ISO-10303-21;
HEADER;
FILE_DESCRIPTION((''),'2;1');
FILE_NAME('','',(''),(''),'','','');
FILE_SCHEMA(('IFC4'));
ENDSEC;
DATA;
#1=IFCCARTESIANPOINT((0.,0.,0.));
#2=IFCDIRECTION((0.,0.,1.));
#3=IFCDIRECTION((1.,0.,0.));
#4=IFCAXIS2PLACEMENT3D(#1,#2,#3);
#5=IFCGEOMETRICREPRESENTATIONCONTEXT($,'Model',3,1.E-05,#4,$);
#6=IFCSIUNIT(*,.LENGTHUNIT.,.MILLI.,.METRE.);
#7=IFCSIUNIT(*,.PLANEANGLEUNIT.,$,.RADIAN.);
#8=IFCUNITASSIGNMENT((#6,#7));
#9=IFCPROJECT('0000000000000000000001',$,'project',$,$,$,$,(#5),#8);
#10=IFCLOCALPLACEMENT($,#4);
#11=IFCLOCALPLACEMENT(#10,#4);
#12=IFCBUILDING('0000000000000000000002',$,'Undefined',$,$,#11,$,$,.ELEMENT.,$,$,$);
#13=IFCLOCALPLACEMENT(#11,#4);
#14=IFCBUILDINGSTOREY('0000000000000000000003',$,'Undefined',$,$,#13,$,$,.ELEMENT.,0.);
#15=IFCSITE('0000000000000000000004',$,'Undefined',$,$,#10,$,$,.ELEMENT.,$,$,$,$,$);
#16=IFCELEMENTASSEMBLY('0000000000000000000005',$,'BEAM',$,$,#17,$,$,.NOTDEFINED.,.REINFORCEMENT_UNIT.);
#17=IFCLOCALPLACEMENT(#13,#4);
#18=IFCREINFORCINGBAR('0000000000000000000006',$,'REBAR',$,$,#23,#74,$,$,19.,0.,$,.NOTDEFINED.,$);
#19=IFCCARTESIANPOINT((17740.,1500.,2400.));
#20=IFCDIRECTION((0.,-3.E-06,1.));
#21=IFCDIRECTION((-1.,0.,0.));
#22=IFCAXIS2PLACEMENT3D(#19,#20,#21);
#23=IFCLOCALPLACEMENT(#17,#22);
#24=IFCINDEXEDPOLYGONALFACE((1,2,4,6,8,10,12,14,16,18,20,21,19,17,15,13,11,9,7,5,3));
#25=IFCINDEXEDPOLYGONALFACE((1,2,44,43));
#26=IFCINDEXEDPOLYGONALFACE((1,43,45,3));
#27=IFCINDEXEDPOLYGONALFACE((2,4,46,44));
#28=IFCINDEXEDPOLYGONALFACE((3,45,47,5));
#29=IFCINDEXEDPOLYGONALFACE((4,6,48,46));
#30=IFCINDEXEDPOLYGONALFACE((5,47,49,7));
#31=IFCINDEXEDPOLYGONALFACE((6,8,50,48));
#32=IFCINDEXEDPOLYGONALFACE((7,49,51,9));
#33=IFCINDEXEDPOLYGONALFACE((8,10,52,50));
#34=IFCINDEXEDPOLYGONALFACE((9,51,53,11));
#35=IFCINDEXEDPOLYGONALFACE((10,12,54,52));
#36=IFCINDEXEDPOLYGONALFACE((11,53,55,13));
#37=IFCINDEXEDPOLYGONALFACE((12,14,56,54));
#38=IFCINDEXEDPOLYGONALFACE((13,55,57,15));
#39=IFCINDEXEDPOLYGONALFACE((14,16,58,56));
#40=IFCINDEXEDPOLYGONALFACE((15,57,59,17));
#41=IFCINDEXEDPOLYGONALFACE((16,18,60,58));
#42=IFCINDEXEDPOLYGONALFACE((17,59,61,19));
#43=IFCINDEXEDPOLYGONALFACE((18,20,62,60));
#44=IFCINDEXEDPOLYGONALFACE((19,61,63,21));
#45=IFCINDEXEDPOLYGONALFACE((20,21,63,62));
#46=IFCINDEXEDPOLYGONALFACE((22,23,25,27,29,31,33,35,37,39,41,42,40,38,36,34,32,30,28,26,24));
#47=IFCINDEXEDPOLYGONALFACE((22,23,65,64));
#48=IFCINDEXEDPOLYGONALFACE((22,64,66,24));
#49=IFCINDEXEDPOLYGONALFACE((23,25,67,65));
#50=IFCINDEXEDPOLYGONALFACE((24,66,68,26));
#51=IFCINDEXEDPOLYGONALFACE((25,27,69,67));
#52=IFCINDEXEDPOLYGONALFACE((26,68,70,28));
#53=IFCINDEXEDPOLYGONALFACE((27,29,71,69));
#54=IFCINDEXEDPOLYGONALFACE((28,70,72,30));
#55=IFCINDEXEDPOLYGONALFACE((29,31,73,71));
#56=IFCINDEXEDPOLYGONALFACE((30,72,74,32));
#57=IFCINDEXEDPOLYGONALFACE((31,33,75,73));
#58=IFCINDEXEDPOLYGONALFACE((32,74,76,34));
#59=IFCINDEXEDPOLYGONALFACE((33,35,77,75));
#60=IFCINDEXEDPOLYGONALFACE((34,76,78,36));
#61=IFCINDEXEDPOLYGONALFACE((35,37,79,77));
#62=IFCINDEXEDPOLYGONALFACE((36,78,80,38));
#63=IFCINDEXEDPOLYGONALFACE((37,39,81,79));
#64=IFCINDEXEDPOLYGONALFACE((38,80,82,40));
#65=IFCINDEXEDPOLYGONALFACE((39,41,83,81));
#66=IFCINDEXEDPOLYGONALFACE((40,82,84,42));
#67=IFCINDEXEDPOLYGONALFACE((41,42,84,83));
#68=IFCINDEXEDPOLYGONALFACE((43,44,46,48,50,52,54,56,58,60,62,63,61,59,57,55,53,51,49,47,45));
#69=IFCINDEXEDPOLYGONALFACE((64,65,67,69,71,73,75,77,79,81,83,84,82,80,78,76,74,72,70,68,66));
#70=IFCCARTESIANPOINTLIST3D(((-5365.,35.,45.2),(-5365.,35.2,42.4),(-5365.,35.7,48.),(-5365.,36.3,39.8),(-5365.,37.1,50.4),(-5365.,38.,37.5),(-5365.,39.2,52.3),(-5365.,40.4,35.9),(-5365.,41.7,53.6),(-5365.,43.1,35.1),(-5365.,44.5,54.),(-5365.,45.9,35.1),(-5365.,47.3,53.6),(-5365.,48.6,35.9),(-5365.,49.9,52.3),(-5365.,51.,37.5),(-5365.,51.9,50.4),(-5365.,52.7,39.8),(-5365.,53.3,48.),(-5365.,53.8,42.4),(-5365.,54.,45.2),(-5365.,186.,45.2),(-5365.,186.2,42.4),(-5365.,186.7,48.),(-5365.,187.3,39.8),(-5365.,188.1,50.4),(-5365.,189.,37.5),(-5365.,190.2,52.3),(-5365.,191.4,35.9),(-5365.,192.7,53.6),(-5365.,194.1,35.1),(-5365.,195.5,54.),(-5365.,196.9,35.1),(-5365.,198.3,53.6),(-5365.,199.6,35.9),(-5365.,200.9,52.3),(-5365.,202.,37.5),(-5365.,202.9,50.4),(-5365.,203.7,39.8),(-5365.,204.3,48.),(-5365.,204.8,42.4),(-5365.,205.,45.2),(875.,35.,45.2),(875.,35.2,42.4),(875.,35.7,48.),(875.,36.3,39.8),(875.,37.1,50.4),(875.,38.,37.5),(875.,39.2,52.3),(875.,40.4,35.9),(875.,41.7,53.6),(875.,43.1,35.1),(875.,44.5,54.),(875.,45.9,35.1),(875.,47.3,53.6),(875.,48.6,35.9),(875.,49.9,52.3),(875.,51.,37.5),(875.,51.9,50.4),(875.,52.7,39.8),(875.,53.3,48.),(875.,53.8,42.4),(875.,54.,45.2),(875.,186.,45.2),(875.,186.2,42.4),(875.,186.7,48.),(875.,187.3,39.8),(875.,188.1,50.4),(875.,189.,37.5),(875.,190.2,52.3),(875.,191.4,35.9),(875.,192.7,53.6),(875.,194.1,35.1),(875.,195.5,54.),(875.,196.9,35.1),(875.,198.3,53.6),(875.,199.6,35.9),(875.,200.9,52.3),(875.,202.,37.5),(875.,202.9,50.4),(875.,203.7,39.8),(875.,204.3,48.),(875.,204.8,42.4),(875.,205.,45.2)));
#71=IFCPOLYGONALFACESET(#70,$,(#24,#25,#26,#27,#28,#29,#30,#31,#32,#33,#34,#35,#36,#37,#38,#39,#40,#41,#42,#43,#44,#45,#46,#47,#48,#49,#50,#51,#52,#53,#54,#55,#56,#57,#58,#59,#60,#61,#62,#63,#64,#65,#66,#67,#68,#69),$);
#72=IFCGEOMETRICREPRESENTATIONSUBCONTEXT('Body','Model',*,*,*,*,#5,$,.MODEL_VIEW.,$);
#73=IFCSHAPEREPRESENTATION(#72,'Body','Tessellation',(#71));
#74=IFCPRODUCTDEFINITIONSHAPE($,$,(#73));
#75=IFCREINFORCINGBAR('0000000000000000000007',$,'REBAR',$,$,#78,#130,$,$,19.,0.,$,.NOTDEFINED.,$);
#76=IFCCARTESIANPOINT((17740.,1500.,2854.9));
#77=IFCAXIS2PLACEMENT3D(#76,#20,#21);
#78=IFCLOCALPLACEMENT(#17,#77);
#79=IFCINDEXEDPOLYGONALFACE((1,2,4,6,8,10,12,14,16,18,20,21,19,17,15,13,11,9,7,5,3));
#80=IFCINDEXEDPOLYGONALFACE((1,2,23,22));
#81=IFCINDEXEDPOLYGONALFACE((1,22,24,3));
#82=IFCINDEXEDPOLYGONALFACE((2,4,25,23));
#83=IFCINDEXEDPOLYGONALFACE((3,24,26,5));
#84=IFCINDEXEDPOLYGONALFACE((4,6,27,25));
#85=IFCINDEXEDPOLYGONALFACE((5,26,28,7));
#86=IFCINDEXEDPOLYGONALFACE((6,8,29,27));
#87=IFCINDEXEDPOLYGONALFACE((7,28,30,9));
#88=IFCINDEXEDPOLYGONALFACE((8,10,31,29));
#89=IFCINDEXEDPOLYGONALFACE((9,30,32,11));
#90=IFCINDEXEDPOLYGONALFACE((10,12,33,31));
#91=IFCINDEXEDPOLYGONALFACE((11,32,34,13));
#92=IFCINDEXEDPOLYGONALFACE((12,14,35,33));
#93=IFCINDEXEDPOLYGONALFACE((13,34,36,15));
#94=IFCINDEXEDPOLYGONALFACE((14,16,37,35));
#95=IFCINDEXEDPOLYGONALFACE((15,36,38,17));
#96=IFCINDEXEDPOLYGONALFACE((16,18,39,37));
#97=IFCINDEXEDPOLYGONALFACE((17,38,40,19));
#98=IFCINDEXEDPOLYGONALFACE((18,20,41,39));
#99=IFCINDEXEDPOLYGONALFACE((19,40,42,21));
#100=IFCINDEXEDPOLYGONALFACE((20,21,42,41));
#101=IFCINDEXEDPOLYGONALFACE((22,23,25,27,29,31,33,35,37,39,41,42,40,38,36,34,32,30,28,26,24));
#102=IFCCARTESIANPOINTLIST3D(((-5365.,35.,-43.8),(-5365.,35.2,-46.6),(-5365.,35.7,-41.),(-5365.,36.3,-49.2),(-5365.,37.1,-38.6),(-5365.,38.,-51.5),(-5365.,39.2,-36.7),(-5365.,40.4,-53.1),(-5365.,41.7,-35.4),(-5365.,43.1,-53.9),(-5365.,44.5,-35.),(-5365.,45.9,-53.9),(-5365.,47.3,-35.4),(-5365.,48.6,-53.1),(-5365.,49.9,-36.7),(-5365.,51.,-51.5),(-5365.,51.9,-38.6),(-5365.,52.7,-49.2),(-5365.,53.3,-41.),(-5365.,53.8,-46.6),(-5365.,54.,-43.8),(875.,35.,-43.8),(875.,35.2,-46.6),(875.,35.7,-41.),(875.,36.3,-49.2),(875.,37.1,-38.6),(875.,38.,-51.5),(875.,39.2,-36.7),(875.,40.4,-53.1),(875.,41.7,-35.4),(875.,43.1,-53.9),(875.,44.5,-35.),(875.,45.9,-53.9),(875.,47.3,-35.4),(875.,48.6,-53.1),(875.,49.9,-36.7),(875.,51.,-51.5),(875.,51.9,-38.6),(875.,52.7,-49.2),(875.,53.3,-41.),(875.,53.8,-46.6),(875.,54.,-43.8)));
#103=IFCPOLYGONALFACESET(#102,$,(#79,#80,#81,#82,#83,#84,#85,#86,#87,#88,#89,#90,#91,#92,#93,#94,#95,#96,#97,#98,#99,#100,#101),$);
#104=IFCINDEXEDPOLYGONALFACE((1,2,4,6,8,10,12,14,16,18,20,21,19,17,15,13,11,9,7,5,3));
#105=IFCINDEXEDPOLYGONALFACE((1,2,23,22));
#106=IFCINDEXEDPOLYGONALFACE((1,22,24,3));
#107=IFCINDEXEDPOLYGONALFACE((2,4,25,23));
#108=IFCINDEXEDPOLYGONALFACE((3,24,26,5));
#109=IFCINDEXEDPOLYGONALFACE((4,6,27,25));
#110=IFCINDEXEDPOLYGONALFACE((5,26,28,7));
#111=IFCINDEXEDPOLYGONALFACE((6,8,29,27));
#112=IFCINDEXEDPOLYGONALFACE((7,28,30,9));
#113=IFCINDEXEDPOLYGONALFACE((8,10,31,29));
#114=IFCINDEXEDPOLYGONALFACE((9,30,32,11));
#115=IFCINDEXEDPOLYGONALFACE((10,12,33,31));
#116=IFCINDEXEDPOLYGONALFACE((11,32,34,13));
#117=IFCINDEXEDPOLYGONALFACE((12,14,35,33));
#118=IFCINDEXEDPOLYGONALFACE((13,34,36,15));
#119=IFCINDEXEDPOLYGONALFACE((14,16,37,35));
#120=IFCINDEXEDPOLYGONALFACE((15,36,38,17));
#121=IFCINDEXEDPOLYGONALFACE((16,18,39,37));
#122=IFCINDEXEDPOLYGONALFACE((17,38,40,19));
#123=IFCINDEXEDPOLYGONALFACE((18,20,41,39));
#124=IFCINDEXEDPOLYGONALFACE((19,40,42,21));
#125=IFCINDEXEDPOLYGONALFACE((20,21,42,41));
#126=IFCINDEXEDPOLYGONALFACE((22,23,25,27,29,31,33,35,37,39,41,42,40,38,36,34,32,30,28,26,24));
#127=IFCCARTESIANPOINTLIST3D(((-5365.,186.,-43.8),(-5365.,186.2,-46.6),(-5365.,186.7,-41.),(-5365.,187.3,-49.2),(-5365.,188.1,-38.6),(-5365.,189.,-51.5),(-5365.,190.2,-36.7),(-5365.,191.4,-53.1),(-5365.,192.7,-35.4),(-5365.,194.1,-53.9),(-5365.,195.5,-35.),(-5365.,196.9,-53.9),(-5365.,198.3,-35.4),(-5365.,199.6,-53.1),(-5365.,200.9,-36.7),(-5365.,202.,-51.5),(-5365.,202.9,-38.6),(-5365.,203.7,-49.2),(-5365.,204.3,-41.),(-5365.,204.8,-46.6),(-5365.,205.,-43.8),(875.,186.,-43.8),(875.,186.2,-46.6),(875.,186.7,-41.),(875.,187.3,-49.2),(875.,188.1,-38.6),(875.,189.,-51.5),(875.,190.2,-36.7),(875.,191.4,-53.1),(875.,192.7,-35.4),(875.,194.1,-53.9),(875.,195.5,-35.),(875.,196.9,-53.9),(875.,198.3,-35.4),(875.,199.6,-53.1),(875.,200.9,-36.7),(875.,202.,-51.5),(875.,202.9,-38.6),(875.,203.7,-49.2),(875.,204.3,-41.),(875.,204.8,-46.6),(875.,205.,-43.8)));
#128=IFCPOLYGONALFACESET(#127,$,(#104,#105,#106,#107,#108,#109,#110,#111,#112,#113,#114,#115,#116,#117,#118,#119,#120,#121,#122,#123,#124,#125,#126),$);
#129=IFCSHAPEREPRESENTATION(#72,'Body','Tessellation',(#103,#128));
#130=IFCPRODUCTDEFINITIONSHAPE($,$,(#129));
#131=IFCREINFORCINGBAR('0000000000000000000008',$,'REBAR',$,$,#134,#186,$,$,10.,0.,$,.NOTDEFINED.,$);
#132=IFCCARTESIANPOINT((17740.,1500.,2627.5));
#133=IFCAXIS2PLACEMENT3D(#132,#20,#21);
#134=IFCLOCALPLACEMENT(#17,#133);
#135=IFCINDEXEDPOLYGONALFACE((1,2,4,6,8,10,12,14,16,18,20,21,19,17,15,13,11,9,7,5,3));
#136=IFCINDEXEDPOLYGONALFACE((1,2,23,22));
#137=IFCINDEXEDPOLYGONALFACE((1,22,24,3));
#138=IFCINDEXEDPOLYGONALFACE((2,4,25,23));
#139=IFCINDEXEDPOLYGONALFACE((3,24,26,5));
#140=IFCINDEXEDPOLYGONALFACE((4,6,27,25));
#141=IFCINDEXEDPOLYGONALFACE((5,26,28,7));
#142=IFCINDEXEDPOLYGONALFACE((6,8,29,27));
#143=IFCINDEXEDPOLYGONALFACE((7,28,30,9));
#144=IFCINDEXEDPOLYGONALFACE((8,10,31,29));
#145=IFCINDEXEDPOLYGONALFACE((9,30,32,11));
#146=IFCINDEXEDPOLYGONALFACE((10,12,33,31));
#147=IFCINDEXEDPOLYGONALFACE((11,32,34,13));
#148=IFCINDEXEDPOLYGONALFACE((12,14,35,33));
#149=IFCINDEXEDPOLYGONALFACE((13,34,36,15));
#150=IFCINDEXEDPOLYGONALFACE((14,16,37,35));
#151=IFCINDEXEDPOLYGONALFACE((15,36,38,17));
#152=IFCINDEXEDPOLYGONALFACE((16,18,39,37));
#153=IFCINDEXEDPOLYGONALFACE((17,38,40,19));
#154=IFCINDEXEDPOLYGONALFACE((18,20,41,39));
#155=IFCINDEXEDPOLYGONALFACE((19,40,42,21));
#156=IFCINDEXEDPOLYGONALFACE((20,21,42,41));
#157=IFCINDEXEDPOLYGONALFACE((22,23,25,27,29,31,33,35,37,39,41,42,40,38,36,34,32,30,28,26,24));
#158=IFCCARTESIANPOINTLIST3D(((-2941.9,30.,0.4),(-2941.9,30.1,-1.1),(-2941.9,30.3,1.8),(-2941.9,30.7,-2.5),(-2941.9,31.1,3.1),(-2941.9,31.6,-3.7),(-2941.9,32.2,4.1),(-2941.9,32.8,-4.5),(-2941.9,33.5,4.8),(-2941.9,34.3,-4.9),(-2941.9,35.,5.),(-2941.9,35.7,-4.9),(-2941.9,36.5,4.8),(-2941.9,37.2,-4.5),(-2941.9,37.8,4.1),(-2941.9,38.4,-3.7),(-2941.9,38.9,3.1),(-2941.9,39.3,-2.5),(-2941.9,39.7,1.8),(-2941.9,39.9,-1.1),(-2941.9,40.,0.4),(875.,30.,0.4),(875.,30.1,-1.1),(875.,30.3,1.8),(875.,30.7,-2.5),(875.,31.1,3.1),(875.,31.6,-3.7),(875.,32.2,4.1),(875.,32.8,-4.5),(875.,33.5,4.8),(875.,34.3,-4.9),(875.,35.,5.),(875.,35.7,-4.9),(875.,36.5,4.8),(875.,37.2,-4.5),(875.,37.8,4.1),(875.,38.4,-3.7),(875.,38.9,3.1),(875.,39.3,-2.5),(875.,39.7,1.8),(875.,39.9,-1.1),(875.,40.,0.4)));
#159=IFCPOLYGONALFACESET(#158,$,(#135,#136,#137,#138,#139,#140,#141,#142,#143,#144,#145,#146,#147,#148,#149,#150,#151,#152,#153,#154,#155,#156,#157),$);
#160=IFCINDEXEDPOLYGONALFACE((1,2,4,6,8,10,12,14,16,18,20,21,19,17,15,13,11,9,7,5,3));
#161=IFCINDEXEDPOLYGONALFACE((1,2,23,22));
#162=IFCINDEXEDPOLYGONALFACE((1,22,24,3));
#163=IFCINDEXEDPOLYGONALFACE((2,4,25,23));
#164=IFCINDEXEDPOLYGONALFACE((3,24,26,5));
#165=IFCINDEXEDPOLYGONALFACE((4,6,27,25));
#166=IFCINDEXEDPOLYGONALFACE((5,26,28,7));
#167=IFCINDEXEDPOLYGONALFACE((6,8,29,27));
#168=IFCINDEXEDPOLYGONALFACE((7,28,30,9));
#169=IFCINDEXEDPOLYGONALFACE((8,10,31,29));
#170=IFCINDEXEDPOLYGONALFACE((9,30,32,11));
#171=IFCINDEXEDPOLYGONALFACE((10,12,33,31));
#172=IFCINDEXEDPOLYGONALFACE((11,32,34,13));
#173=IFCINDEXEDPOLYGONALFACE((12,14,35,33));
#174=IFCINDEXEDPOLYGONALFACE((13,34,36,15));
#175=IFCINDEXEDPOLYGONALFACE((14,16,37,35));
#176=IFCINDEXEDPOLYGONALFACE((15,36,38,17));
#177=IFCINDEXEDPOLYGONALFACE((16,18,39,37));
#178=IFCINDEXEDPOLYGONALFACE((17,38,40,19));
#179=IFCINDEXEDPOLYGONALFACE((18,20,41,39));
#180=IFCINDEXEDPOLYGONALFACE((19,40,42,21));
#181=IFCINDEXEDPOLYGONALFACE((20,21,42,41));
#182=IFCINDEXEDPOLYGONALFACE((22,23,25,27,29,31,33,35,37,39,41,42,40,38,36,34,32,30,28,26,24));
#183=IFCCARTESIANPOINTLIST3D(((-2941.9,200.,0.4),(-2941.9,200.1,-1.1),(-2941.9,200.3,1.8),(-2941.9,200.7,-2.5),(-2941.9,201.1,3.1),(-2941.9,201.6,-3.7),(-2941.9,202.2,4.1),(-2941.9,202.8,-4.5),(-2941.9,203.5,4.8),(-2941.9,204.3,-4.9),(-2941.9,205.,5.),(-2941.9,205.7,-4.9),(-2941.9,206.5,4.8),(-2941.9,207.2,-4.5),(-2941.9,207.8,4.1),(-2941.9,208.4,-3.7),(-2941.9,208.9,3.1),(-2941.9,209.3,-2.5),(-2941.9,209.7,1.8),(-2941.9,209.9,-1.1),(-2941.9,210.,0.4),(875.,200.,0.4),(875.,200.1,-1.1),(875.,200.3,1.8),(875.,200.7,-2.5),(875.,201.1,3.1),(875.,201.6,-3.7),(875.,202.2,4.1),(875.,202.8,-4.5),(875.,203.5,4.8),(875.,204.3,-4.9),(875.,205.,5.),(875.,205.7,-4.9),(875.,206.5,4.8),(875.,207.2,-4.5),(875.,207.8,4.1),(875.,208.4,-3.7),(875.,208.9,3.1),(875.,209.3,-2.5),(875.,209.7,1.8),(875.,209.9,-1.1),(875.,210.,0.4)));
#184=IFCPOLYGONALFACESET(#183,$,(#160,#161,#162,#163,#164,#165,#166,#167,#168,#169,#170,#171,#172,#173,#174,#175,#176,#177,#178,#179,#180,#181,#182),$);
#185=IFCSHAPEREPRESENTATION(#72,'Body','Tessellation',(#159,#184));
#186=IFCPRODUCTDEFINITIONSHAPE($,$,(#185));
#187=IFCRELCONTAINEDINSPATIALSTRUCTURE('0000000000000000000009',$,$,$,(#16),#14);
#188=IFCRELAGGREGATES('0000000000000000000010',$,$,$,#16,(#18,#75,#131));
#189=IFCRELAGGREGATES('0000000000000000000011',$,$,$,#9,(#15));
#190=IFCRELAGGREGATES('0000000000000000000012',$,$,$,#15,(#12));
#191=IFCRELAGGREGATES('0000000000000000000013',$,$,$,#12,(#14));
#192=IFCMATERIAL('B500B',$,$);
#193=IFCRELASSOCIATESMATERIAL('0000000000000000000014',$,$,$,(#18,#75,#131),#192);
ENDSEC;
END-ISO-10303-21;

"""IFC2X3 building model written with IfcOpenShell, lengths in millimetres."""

from ifc_helpers import new_model, entity, si_unit, frame, origin_with_axes, place, context, subcontext, project, spatial, source, transform, mapped, material, element, aggregate, save


model = new_model("IFC2X3")

# Units and contexts
model_context = context("Model", 3, precision=1e-05, world=origin_with_axes())
body_context = subcontext(model_context, "Body", "Model", "MODEL_VIEW")
ifc_project = project(units=[si_unit("LENGTHUNIT", "METRE", prefix="MILLI"), si_unit("PLANEANGLEUNIT", "RADIAN")], contexts=[model_context])

# Site, building, storey
site_placement = place(None, origin_with_axes())
site = spatial("IfcSite", under=ifc_project, at=site_placement, Name="Undefined", CompositionType="ELEMENT")
building_placement = place(site_placement, origin_with_axes())
building = spatial("IfcBuilding", under=site, at=building_placement, Name="Undefined", CompositionType="ELEMENT")
storey_placement = place(building_placement, origin_with_axes())
storey = spatial("IfcBuildingStorey", under=building, at=storey_placement, Name="Undefined", CompositionType="ELEMENT", Elevation=0.0)

# Element assembly
assembly_1_placement = place(storey_placement, origin_with_axes())
assembly_1 = element("IfcElementAssembly", 1, at=assembly_1_placement, inside=storey, Name="BEAM", AssemblyPlace="NOTDEFINED", PredefinedType="REINFORCEMENT_UNIT")

# Reinforcing bars
ifc_material_1 = material(Name="B500B")
shared_shape_1 = source(origin_with_axes(), body_context, "Body", "AdvancedSweptSolid", [
    entity("IfcSweptDiskSolid", entity("IfcTrimmedCurve", entity("IfcLine", entity("IfcCartesianPoint", [0.0, 0.0, 0.0]), entity("IfcVector", entity("IfcDirection", [1.0, 0.0, 0.0]), 1.0)), [entity("IfcParameterValue", 0.0)], [entity("IfcParameterValue", 6240.002834)], True, "PARAMETER"), 9.5, None, 0.0, 6240.0),
])
shared_shape_2 = source(origin_with_axes(), body_context, "Body", "AdvancedSweptSolid", [
    entity("IfcSweptDiskSolid", entity("IfcTrimmedCurve", entity("IfcLine", entity("IfcCartesianPoint", [0.0, 0.0, 0.0]), entity("IfcVector", entity("IfcDirection", [1.0, 0.0, 0.0]), 1.0)), [entity("IfcParameterValue", 0.0)], [entity("IfcParameterValue", 6240.002834)], True, "PARAMETER"), 9.5, None, 0.0, 6240.0),
])
reinforcing_bar_1_placement = place(assembly_1_placement, frame((17740.0, 1500.0, 2400.0), z_axis=(0.0, -0.000003, 1.0), x_axis=(-1.0, 0.0, 0.0)))
reinforcing_bar_1 = element("IfcReinforcingBar", 2, at=reinforcing_bar_1_placement, material=ifc_material_1, Name="REBAR", BarRole="NOTDEFINED", CrossSectionArea=0.0, NominalDiameter=19.0, context=body_context, shape_type="MappedRepresentation", body=[
    mapped(shared_shape_1, transform((-5365.0, 44.5, 44.5))),
    mapped(shared_shape_2, transform((-5365.0, 195.5, 44.5))),
])
shared_shape_3 = source(origin_with_axes(), body_context, "Body", "AdvancedSweptSolid", [
    entity("IfcSweptDiskSolid", entity("IfcTrimmedCurve", entity("IfcLine", entity("IfcCartesianPoint", [0.0, 0.0, 0.0]), entity("IfcVector", entity("IfcDirection", [1.0, 0.0, 0.0]), 1.0)), [entity("IfcParameterValue", 0.0)], [entity("IfcParameterValue", 6240.002834)], True, "PARAMETER"), 9.5, None, 0.0, 6240.0),
])
shared_shape_4 = source(origin_with_axes(), body_context, "Body", "AdvancedSweptSolid", [
    entity("IfcSweptDiskSolid", entity("IfcTrimmedCurve", entity("IfcLine", entity("IfcCartesianPoint", [0.0, 0.0, 0.0]), entity("IfcVector", entity("IfcDirection", [1.0, 0.0, 0.0]), 1.0)), [entity("IfcParameterValue", 0.0)], [entity("IfcParameterValue", 6240.002834)], True, "PARAMETER"), 9.5, None, 0.0, 6240.0),
])
reinforcing_bar_2_placement = place(assembly_1_placement, frame((17740.0, 1500.0, 2854.9), z_axis=(0.0, -0.000003, 1.0), x_axis=(-1.0, 0.0, 0.0)))
reinforcing_bar_2 = element("IfcReinforcingBar", 3, at=reinforcing_bar_2_placement, material=ifc_material_1, Name="REBAR", BarRole="NOTDEFINED", CrossSectionArea=0.0, NominalDiameter=19.0, context=body_context, shape_type="MappedRepresentation", body=[
    mapped(shared_shape_3, transform((-5365.0, 44.5, -44.5))),
    mapped(shared_shape_4, transform((-5365.0, 195.5, -44.5))),
])
shared_shape_5 = source(origin_with_axes(), body_context, "Body", "AdvancedSweptSolid", [
    entity("IfcSweptDiskSolid", entity("IfcTrimmedCurve", entity("IfcLine", entity("IfcCartesianPoint", [0.0, 0.0, 0.0]), entity("IfcVector", entity("IfcDirection", [1.0, 0.0, 0.0]), 1.0)), [entity("IfcParameterValue", 0.0)], [entity("IfcParameterValue", 3816.932835)], True, "PARAMETER"), 5.0, None, 0.0, 3816.9),
])
shared_shape_6 = source(origin_with_axes(), body_context, "Body", "AdvancedSweptSolid", [
    entity("IfcSweptDiskSolid", entity("IfcTrimmedCurve", entity("IfcLine", entity("IfcCartesianPoint", [0.0, 0.0, 0.0]), entity("IfcVector", entity("IfcDirection", [1.0, 0.0, 0.0]), 1.0)), [entity("IfcParameterValue", 0.0)], [entity("IfcParameterValue", 3816.932835)], True, "PARAMETER"), 5.0, None, 0.0, 3816.9),
])
reinforcing_bar_3_placement = place(assembly_1_placement, frame((17740.0, 1500.0, 2627.5), z_axis=(0.0, -0.000003, 1.0), x_axis=(-1.0, 0.0, 0.0)))
reinforcing_bar_3 = element("IfcReinforcingBar", 4, at=reinforcing_bar_3_placement, material=ifc_material_1, Name="REBAR", BarRole="NOTDEFINED", CrossSectionArea=0.0, NominalDiameter=10.0, context=body_context, shape_type="MappedRepresentation", body=[
    mapped(shared_shape_5, transform((-2941.9, 35.0, 0.0))),
    mapped(shared_shape_6, transform((-2941.9, 205.0, 0.0))),
])
aggregate(assembly_1, [reinforcing_bar_1, reinforcing_bar_2, reinforcing_bar_3])

save(model, "model.ifc")
